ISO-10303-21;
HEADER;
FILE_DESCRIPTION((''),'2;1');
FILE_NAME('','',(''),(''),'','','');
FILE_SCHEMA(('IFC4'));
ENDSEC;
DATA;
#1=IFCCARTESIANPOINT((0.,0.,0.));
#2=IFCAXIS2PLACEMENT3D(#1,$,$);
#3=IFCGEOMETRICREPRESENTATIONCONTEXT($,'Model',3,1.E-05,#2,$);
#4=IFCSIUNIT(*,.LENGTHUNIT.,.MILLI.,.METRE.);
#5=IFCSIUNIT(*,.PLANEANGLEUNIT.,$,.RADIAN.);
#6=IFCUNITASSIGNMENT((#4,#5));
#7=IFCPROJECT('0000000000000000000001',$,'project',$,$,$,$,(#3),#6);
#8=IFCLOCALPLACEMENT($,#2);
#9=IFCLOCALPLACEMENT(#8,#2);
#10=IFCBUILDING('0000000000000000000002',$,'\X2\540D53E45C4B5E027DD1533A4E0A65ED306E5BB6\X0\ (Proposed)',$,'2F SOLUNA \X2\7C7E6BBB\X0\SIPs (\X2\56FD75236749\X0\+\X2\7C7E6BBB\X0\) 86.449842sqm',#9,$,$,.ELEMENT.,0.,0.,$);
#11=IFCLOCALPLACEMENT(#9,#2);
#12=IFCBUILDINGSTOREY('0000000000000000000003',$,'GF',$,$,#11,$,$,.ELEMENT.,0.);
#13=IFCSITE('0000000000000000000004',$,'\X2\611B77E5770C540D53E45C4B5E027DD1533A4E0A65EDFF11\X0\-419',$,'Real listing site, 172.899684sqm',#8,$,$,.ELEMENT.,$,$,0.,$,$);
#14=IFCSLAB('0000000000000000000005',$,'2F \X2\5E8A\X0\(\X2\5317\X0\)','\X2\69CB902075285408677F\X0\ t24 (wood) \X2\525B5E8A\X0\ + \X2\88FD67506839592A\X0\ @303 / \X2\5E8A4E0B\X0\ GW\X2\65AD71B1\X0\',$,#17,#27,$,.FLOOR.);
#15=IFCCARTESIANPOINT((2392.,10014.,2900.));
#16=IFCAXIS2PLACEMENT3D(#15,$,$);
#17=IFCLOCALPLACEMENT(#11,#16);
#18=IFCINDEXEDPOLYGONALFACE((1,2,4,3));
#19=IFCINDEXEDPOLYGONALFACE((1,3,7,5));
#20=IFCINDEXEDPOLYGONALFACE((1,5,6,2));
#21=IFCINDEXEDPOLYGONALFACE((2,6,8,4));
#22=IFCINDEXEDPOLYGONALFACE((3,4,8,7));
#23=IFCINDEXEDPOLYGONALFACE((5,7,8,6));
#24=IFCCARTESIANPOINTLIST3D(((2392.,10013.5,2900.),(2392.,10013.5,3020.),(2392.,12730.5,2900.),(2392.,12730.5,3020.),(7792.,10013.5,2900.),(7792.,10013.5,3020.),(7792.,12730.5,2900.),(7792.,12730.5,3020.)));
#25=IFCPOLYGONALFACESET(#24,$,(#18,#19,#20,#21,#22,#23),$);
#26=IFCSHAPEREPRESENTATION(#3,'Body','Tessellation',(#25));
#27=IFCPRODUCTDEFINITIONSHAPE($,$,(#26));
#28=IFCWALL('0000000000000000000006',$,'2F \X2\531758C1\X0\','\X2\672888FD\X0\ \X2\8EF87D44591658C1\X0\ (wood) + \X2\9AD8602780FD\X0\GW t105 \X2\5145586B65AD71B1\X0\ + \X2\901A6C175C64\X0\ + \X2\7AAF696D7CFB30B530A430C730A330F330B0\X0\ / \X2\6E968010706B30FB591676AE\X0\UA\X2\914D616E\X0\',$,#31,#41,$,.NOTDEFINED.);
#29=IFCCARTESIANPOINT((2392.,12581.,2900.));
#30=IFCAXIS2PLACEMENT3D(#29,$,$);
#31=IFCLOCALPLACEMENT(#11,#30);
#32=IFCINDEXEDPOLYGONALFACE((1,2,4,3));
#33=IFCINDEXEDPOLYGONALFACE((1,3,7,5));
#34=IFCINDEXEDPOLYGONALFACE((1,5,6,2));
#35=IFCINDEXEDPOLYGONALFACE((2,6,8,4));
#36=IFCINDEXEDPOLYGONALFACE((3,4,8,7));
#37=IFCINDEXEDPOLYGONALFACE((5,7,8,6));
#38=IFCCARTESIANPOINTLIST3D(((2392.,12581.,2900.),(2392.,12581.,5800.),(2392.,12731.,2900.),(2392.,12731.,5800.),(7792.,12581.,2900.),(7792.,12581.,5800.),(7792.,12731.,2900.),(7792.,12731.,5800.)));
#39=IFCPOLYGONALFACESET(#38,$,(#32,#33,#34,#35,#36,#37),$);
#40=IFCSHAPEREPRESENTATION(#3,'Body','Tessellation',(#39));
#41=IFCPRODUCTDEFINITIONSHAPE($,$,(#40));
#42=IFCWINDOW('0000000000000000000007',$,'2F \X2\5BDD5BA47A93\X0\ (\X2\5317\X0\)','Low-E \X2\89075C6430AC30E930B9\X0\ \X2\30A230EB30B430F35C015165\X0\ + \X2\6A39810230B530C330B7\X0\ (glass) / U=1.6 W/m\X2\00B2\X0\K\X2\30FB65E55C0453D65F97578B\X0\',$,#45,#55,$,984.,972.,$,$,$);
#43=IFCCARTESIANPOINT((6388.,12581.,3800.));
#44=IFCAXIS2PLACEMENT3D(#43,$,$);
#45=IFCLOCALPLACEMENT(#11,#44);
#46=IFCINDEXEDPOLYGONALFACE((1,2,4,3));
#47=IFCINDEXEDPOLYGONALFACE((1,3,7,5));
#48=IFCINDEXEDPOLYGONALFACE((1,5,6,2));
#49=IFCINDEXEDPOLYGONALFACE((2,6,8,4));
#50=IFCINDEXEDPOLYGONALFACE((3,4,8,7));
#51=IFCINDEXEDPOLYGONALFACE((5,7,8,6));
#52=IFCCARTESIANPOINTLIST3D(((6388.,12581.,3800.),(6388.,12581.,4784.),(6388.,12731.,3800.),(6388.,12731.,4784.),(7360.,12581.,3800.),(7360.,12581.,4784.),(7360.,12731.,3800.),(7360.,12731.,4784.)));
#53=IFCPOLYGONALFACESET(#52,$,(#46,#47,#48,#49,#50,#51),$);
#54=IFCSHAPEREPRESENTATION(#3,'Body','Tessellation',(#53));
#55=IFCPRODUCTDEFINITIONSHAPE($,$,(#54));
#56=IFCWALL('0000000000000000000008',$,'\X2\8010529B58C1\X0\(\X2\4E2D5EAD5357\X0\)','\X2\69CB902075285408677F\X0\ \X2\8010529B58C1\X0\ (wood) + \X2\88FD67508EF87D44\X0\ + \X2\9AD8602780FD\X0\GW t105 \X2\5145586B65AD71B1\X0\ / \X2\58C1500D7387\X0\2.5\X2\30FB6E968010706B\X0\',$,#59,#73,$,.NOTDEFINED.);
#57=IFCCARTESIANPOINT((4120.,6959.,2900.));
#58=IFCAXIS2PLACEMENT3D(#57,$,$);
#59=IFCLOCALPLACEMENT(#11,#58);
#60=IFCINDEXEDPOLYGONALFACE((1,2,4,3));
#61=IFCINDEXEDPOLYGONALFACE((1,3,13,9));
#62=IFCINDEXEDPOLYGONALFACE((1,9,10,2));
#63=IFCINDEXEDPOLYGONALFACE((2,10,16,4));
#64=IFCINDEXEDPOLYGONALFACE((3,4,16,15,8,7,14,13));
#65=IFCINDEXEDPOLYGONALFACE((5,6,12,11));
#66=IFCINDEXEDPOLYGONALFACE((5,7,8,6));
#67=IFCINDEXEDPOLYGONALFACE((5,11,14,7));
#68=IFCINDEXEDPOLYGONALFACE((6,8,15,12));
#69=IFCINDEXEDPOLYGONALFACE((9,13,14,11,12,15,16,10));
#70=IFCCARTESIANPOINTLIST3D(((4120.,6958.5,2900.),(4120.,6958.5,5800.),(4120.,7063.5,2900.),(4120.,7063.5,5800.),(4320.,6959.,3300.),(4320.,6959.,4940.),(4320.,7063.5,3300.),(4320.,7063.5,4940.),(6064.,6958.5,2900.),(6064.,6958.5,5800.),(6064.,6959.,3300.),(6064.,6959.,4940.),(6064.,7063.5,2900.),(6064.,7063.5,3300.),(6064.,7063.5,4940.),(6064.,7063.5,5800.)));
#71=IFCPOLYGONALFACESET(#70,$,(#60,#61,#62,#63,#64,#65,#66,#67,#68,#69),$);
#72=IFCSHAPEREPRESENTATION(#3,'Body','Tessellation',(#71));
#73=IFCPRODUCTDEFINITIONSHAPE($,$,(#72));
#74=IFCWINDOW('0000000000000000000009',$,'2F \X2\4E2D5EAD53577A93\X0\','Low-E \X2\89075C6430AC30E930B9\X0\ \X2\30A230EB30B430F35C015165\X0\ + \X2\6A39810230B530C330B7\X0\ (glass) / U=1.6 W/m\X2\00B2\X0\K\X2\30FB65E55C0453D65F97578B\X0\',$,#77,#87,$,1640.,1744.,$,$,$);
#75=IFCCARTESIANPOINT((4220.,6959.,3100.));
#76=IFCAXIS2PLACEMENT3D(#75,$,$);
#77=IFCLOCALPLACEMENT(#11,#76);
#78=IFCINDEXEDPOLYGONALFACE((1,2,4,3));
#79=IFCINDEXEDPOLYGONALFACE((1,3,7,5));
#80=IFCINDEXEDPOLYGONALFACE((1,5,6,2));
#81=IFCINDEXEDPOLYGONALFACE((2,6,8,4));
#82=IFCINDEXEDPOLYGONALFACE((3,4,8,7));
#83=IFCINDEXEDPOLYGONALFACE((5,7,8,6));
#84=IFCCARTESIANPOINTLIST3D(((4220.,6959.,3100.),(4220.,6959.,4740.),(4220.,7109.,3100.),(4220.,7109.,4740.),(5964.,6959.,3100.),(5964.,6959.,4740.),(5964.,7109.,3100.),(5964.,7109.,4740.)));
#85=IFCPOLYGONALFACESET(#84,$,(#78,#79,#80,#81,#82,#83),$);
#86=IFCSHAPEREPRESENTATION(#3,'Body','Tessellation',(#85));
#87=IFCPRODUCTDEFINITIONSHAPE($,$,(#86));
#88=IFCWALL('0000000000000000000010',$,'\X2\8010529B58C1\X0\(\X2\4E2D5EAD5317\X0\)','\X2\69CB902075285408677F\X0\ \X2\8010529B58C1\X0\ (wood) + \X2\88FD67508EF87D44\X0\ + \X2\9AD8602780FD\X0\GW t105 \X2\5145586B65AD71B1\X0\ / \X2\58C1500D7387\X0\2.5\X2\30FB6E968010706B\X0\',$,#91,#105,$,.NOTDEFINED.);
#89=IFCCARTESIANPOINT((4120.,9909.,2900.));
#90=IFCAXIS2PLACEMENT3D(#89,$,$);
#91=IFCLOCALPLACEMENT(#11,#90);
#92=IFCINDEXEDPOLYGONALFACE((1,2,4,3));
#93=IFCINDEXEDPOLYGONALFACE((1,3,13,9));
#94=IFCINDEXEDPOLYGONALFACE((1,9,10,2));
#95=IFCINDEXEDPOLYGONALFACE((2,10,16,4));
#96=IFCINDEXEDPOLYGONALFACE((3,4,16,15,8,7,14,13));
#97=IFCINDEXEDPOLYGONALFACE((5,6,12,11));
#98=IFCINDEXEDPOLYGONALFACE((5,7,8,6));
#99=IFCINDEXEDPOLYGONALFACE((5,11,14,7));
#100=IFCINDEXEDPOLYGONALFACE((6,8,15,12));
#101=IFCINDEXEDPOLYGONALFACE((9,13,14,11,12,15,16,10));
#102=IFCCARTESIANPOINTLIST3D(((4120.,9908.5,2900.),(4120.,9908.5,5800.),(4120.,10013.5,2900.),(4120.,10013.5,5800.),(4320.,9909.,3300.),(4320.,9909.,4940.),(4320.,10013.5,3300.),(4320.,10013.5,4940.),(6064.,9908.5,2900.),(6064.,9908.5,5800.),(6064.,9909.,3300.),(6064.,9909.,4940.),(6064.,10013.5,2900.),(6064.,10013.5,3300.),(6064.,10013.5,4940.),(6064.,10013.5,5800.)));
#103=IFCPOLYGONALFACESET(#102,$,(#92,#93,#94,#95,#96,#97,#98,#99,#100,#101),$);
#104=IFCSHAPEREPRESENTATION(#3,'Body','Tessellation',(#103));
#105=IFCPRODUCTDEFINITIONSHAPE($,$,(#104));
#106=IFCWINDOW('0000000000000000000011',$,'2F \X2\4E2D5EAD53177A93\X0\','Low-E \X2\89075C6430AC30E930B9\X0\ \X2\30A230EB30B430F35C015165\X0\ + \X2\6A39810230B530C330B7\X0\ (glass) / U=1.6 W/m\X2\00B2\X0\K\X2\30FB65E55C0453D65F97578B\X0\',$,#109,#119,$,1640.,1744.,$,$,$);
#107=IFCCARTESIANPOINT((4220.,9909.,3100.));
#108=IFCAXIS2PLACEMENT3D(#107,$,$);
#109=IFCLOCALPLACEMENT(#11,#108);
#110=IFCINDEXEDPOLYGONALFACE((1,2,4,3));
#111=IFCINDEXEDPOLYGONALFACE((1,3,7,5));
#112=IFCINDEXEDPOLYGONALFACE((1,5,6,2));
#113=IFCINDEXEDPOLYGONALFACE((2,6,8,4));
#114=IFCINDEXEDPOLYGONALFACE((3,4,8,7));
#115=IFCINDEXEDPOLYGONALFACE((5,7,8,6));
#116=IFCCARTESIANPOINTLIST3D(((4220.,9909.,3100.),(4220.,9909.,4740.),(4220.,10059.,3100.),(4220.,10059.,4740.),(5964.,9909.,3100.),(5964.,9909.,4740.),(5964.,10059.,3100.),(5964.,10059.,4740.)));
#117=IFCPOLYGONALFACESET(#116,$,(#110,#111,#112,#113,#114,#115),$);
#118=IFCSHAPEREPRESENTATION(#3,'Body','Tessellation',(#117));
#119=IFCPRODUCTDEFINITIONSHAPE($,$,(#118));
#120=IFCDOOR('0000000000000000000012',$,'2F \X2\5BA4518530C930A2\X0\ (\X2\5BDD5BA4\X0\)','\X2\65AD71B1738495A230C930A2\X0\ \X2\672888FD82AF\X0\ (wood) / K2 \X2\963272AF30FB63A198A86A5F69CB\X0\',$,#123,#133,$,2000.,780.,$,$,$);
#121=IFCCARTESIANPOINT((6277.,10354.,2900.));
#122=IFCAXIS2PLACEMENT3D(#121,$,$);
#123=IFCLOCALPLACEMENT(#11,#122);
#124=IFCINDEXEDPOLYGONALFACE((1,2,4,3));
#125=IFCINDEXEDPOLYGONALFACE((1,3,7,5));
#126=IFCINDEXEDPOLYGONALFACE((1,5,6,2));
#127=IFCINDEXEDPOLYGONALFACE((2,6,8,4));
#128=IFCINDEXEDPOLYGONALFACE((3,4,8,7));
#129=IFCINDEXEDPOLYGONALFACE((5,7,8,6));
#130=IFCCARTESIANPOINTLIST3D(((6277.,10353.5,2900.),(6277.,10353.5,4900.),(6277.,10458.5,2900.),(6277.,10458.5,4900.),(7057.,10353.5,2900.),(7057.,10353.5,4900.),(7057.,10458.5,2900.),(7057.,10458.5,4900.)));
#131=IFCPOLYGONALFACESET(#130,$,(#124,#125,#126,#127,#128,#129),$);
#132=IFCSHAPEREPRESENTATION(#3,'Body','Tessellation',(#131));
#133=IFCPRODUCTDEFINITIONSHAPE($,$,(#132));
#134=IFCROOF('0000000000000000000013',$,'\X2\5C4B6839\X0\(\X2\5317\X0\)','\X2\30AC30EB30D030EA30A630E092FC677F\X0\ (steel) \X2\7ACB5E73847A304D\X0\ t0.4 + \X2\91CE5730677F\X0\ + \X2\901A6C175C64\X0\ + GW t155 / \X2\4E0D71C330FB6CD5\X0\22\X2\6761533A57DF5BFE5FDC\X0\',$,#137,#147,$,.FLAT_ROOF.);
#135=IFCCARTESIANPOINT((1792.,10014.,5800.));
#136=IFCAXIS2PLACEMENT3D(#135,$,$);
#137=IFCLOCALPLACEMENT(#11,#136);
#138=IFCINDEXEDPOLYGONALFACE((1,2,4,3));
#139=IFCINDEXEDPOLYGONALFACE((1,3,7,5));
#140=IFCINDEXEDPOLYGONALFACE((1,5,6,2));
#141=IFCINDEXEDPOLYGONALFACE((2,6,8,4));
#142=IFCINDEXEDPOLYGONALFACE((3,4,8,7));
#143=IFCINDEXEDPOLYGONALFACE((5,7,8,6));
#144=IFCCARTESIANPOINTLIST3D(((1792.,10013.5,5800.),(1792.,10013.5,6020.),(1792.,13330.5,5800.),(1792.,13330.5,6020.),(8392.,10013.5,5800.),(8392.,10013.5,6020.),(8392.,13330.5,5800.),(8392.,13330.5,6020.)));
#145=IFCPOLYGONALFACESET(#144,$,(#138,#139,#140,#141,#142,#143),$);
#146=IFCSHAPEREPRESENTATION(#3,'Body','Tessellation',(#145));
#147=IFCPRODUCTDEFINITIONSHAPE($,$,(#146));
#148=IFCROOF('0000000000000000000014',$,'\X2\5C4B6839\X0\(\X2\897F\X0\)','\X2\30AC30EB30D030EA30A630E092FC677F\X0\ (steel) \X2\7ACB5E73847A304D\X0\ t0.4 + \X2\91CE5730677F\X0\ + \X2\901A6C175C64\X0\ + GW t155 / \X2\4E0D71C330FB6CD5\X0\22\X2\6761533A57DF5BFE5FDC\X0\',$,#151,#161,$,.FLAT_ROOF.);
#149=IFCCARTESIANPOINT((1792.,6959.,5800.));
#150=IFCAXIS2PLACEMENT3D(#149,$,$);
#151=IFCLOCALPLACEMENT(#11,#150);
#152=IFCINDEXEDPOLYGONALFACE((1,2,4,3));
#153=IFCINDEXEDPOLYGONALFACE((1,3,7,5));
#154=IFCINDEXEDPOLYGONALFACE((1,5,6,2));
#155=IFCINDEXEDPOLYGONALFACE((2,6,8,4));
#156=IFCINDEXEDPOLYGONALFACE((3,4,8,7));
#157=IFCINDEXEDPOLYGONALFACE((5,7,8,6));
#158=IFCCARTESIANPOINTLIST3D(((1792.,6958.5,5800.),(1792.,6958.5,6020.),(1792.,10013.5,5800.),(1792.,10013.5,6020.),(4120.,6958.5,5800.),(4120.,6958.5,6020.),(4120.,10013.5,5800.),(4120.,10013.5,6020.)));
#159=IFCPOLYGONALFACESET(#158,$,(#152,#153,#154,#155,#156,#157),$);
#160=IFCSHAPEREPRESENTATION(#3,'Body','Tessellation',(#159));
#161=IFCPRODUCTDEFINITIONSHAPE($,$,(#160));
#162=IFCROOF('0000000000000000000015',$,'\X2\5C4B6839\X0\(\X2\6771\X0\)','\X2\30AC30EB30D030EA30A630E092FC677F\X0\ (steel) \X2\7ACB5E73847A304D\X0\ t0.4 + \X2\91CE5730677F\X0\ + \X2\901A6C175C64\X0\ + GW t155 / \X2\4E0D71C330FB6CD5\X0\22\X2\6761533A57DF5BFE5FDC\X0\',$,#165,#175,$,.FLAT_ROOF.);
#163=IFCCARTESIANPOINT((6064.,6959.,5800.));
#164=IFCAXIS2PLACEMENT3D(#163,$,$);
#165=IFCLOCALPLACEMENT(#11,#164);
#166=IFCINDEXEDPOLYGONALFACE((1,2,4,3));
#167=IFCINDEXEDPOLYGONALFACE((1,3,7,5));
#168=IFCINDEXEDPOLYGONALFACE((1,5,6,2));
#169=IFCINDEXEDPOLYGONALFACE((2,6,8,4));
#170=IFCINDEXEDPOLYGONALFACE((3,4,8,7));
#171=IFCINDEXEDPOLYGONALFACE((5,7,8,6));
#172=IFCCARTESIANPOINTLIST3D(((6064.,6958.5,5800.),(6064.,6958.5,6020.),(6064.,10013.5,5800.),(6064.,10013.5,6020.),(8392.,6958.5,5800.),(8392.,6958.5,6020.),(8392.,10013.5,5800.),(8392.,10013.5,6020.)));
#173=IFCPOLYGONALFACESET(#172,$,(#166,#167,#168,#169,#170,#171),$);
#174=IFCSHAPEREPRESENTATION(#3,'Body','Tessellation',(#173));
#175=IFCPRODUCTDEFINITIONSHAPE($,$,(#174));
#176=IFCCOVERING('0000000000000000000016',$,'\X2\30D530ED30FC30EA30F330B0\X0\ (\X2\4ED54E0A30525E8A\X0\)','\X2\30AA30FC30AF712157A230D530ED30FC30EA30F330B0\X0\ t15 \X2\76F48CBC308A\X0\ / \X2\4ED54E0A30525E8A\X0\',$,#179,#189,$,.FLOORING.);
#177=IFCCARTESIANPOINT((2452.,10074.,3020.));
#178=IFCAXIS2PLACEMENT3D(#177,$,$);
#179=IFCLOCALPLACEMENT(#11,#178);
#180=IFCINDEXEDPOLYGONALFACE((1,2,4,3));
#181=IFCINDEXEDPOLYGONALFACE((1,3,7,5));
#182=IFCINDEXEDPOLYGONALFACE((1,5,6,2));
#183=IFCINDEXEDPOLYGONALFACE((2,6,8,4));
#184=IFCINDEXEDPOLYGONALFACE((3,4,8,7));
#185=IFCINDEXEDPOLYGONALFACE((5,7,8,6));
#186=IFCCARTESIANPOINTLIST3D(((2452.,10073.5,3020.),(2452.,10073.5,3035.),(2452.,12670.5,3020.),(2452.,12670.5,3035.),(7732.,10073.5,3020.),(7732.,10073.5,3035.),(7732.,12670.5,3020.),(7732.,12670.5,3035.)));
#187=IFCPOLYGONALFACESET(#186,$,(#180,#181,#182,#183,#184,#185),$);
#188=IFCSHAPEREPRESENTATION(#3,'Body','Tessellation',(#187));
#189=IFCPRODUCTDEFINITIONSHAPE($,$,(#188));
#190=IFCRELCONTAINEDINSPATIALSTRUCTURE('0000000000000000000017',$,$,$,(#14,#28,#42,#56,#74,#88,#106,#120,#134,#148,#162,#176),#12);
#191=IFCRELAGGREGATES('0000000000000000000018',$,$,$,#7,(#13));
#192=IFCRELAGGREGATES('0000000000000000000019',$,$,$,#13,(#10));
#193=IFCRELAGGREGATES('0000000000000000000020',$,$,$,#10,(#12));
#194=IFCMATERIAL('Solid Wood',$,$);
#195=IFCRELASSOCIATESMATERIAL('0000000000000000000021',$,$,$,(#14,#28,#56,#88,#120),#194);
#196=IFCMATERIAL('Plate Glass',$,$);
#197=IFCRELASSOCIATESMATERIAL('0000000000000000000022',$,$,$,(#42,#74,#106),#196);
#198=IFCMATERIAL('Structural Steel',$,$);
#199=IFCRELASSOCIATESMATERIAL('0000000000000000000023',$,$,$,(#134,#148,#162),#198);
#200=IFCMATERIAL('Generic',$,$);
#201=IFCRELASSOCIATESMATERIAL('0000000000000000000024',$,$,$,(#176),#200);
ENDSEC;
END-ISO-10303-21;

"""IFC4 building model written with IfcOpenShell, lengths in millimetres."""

from ifc_helpers import new_model, si_unit, frame, frame_2d, origin, place, context, project, spatial, rectangle, extrude, material, element, fill, save


model = new_model("IFC4")

# Units and contexts
model_context = context("Model", 3, precision=1e-05, world=origin())
ifc_project = project(units=[si_unit("LENGTHUNIT", "METRE", prefix="MILLI"), si_unit("PLANEANGLEUNIT", "RADIAN")], contexts=[model_context])

# Site, building, storey
site_placement = place(None, origin())
site = spatial("IfcSite", under=ifc_project, at=site_placement, Name="愛知県名古屋市緑区上旭１-419", ObjectType="Real listing site, 172.899684sqm", CompositionType="ELEMENT", RefElevation=0.0)
building_placement = place(site_placement, origin())
building = spatial("IfcBuilding", under=site, at=building_placement, Name="名古屋市緑区上旭の家 (Proposed)", ObjectType="2F SOLUNA 籾殻SIPs (国産杉+籾殻) 86.449842sqm", CompositionType="ELEMENT", ElevationOfRefHeight=0.0, ElevationOfTerrain=0.0)
storey_placement = place(building_placement, origin())
storey = spatial("IfcBuildingStorey", under=building, at=storey_placement, Name="GF", CompositionType="ELEMENT", Elevation=0.0)

# Slab
ifc_material_1 = material(Name="Solid Wood")
slab_placement = place(storey_placement, frame((2392.0, 10014.0, 2900.0)))
element("IfcSlab", 1, at=slab_placement, inside=storey, material=ifc_material_1, Name="2F 床(北)", Description="構造用合板 t24 (wood) 剛床 + 製材根太 @303 / 床下 GW断熱", PredefinedType="FLOOR", context=model_context, shape_type="SweptSolid", body=[
    extrude(rectangle(XDim=5400.0, YDim=2717.0, at=frame_2d((2700.0, 1358.0))), frame((2392.0, 10014.0, 2900.0)), (0.0, 0.0, 1.0), 120.0),
])

# Walls, openings, windows
wall_1_placement = place(storey_placement, frame((2392.0, 12581.0, 2900.0)))
wall_1 = element("IfcWall", 2, at=wall_1_placement, inside=storey, material=ifc_material_1, Name="2F 北壁", Description="木製 軸組外壁 (wood) + 高性能GW t105 充填断熱 + 通気層 + 窯業系サイディング / 準耐火・外皮UA配慮", PredefinedType="NOTDEFINED", context=model_context, shape_type="SweptSolid", body=[
    extrude(rectangle(XDim=5400.0, YDim=150.0, at=frame_2d((2700.0, 75.0))), frame((2392.0, 12581.0, 2900.0)), (0.0, 0.0, 1.0), 2900.0),
])
opening_1_placement = place(storey_placement, frame((6388.0, 12581.0, 3800.0)))
opening_1 = element("IfcOpeningElement", 3, at=opening_1_placement, cuts=wall_1, PredefinedType="NOTDEFINED", context=model_context, shape_type="SweptSolid", body=[
    extrude(rectangle(XDim=972.0, YDim=150.0, at=frame_2d((486.0, 75.0))), frame((6388.0, 12581.0, 3800.0)), (0.0, 0.0, 1.0), 984.0),
])
ifc_material_2 = material(Name="Plate Glass")
window_1_placement = place(storey_placement, frame((6388.0, 12581.0, 3800.0)))
window_1 = element("IfcWindow", 4, at=window_1_placement, inside=storey, material=ifc_material_2, Name="2F 寝室窓 (北)", Description="Low-E 複層ガラス アルゴン封入 + 樹脂サッシ (glass) / U=1.6 W/m²K・日射取得型", OverallHeight=984.0, OverallWidth=972.0, context=model_context, shape_type="SweptSolid", body=[
    extrude(rectangle(XDim=972.0, YDim=150.0, at=frame_2d((486.0, 75.0))), frame((6388.0, 12581.0, 3800.0)), (0.0, 0.0, 1.0), 984.0),
])
fill(opening_1, window_1)
wall_2_placement = place(storey_placement, frame((4120.0, 6959.0, 2900.0)))
wall_2 = element("IfcWall", 5, at=wall_2_placement, inside=storey, material=ifc_material_1, Name="耐力壁(中庭南)", Description="構造用合板 耐力壁 (wood) + 製材軸組 + 高性能GW t105 充填断熱 / 壁倍率2.5・準耐火", PredefinedType="NOTDEFINED", context=model_context, shape_type="SweptSolid", body=[
    extrude(rectangle(XDim=1944.0, YDim=105.0, at=frame_2d((972.0, 52.0))), frame((4120.0, 6959.0, 2900.0)), (0.0, 0.0, 1.0), 2900.0),
])
opening_2_placement = place(storey_placement, frame((4220.0, 6959.0, 3100.0)))
opening_2 = element("IfcOpeningElement", 6, at=opening_2_placement, cuts=wall_2, PredefinedType="NOTDEFINED", context=model_context, shape_type="SweptSolid", body=[
    extrude(rectangle(XDim=1744.0, YDim=150.0, at=frame_2d((872.0, 75.0))), frame((4220.0, 6959.0, 3100.0)), (0.0, 0.0, 1.0), 1640.0),
])
window_2_placement = place(storey_placement, frame((4220.0, 6959.0, 3100.0)))
window_2 = element("IfcWindow", 7, at=window_2_placement, inside=storey, material=ifc_material_2, Name="2F 中庭南窓", Description="Low-E 複層ガラス アルゴン封入 + 樹脂サッシ (glass) / U=1.6 W/m²K・日射取得型", OverallHeight=1640.0, OverallWidth=1744.0, context=model_context, shape_type="SweptSolid", body=[
    extrude(rectangle(XDim=1744.0, YDim=150.0, at=frame_2d((872.0, 75.0))), frame((4220.0, 6959.0, 3100.0)), (0.0, 0.0, 1.0), 1640.0),
])
fill(opening_2, window_2)
wall_3_placement = place(storey_placement, frame((4120.0, 9909.0, 2900.0)))
wall_3 = element("IfcWall", 8, at=wall_3_placement, inside=storey, material=ifc_material_1, Name="耐力壁(中庭北)", Description="構造用合板 耐力壁 (wood) + 製材軸組 + 高性能GW t105 充填断熱 / 壁倍率2.5・準耐火", PredefinedType="NOTDEFINED", context=model_context, shape_type="SweptSolid", body=[
    extrude(rectangle(XDim=1944.0, YDim=105.0, at=frame_2d((972.0, 52.0))), frame((4120.0, 9909.0, 2900.0)), (0.0, 0.0, 1.0), 2900.0),
])
opening_3_placement = place(storey_placement, frame((4220.0, 9909.0, 3100.0)))
opening_3 = element("IfcOpeningElement", 9, at=opening_3_placement, cuts=wall_3, PredefinedType="NOTDEFINED", context=model_context, shape_type="SweptSolid", body=[
    extrude(rectangle(XDim=1744.0, YDim=150.0, at=frame_2d((872.0, 75.0))), frame((4220.0, 9909.0, 3100.0)), (0.0, 0.0, 1.0), 1640.0),
])
window_3_placement = place(storey_placement, frame((4220.0, 9909.0, 3100.0)))
window_3 = element("IfcWindow", 10, at=window_3_placement, inside=storey, material=ifc_material_2, Name="2F 中庭北窓", Description="Low-E 複層ガラス アルゴン封入 + 樹脂サッシ (glass) / U=1.6 W/m²K・日射取得型", OverallHeight=1640.0, OverallWidth=1744.0, context=model_context, shape_type="SweptSolid", body=[
    extrude(rectangle(XDim=1744.0, YDim=150.0, at=frame_2d((872.0, 75.0))), frame((4220.0, 9909.0, 3100.0)), (0.0, 0.0, 1.0), 1640.0),
])
fill(opening_3, window_3)

# Door
door_placement = place(storey_placement, frame((6277.0, 10354.0, 2900.0)))
element("IfcDoor", 11, at=door_placement, inside=storey, material=ifc_material_1, Name="2F 室内ドア (寝室)", Description="断熱玄関ドア 木製芯 (wood) / K2 防犯・採風機構", OverallHeight=2000.0, OverallWidth=780.0, context=model_context, shape_type="SweptSolid", body=[
    extrude(rectangle(XDim=780.0, YDim=105.0, at=frame_2d((390.0, 52.0))), frame((6277.0, 10354.0, 2900.0)), (0.0, 0.0, 1.0), 2000.0),
])

# Roofs
ifc_material_3 = material(Name="Structural Steel")
for number, where, name in (
    (12, (1792.0, 10014.0, 5800.0), "屋根(北)"),
):
    element("IfcRoof", number, at=place(storey_placement, frame(where)), inside=storey, material=ifc_material_3, Name=name, Description="ガルバリウム鋼板 (steel) 立平葺き t0.4 + 野地板 + 通気層 + GW t155 / 不燃・法22条区域対応", PredefinedType="FLAT_ROOF", context=model_context, shape_type="SweptSolid", body=[
        extrude(rectangle(XDim=6600.0, YDim=3317.0, at=frame_2d((3300.0, 1658.0))), frame((1792.0, 10014.0, 5800.0)), (0.0, 0.0, 1.0), 220.0),
    ])
roof_1_placement = place(storey_placement, frame((1792.0, 6959.0, 5800.0)))
element("IfcRoof", 13, at=roof_1_placement, inside=storey, material=ifc_material_3, Name="屋根(西)", Description="ガルバリウム鋼板 (steel) 立平葺き t0.4 + 野地板 + 通気層 + GW t155 / 不燃・法22条区域対応", PredefinedType="FLAT_ROOF", context=model_context, shape_type="SweptSolid", body=[
    extrude(rectangle(XDim=2328.0, YDim=3055.0, at=frame_2d((1164.0, 1527.0))), frame((1792.0, 6959.0, 5800.0)), (0.0, 0.0, 1.0), 220.0),
])
roof_2_placement = place(storey_placement, frame((6064.0, 6959.0, 5800.0)))
element("IfcRoof", 14, at=roof_2_placement, inside=storey, material=ifc_material_3, Name="屋根(東)", Description="ガルバリウム鋼板 (steel) 立平葺き t0.4 + 野地板 + 通気層 + GW t155 / 不燃・法22条区域対応", PredefinedType="FLAT_ROOF", context=model_context, shape_type="SweptSolid", body=[
    extrude(rectangle(XDim=2328.0, YDim=3055.0, at=frame_2d((1164.0, 1527.0))), frame((6064.0, 6959.0, 5800.0)), (0.0, 0.0, 1.0), 220.0),
])

# Covering
ifc_material_4 = material(Name="Generic")
covering_1_placement = place(storey_placement, frame((2452.0, 10074.0, 3020.0)))
element("IfcCovering", 15, at=covering_1_placement, inside=storey, material=ifc_material_4, Name="フローリング (仕上げ床)", Description="オーク無垢フローリング t15 直貼り / 仕上げ床", PredefinedType="FLOORING", context=model_context, shape_type="SweptSolid", body=[
    extrude(rectangle(XDim=5280.0, YDim=2597.0, at=frame_2d((2640.0, 1298.0))), frame((2452.0, 10074.0, 3020.0)), (0.0, 0.0, 1.0), 15.0),
])

save(model, "model.ifc")
